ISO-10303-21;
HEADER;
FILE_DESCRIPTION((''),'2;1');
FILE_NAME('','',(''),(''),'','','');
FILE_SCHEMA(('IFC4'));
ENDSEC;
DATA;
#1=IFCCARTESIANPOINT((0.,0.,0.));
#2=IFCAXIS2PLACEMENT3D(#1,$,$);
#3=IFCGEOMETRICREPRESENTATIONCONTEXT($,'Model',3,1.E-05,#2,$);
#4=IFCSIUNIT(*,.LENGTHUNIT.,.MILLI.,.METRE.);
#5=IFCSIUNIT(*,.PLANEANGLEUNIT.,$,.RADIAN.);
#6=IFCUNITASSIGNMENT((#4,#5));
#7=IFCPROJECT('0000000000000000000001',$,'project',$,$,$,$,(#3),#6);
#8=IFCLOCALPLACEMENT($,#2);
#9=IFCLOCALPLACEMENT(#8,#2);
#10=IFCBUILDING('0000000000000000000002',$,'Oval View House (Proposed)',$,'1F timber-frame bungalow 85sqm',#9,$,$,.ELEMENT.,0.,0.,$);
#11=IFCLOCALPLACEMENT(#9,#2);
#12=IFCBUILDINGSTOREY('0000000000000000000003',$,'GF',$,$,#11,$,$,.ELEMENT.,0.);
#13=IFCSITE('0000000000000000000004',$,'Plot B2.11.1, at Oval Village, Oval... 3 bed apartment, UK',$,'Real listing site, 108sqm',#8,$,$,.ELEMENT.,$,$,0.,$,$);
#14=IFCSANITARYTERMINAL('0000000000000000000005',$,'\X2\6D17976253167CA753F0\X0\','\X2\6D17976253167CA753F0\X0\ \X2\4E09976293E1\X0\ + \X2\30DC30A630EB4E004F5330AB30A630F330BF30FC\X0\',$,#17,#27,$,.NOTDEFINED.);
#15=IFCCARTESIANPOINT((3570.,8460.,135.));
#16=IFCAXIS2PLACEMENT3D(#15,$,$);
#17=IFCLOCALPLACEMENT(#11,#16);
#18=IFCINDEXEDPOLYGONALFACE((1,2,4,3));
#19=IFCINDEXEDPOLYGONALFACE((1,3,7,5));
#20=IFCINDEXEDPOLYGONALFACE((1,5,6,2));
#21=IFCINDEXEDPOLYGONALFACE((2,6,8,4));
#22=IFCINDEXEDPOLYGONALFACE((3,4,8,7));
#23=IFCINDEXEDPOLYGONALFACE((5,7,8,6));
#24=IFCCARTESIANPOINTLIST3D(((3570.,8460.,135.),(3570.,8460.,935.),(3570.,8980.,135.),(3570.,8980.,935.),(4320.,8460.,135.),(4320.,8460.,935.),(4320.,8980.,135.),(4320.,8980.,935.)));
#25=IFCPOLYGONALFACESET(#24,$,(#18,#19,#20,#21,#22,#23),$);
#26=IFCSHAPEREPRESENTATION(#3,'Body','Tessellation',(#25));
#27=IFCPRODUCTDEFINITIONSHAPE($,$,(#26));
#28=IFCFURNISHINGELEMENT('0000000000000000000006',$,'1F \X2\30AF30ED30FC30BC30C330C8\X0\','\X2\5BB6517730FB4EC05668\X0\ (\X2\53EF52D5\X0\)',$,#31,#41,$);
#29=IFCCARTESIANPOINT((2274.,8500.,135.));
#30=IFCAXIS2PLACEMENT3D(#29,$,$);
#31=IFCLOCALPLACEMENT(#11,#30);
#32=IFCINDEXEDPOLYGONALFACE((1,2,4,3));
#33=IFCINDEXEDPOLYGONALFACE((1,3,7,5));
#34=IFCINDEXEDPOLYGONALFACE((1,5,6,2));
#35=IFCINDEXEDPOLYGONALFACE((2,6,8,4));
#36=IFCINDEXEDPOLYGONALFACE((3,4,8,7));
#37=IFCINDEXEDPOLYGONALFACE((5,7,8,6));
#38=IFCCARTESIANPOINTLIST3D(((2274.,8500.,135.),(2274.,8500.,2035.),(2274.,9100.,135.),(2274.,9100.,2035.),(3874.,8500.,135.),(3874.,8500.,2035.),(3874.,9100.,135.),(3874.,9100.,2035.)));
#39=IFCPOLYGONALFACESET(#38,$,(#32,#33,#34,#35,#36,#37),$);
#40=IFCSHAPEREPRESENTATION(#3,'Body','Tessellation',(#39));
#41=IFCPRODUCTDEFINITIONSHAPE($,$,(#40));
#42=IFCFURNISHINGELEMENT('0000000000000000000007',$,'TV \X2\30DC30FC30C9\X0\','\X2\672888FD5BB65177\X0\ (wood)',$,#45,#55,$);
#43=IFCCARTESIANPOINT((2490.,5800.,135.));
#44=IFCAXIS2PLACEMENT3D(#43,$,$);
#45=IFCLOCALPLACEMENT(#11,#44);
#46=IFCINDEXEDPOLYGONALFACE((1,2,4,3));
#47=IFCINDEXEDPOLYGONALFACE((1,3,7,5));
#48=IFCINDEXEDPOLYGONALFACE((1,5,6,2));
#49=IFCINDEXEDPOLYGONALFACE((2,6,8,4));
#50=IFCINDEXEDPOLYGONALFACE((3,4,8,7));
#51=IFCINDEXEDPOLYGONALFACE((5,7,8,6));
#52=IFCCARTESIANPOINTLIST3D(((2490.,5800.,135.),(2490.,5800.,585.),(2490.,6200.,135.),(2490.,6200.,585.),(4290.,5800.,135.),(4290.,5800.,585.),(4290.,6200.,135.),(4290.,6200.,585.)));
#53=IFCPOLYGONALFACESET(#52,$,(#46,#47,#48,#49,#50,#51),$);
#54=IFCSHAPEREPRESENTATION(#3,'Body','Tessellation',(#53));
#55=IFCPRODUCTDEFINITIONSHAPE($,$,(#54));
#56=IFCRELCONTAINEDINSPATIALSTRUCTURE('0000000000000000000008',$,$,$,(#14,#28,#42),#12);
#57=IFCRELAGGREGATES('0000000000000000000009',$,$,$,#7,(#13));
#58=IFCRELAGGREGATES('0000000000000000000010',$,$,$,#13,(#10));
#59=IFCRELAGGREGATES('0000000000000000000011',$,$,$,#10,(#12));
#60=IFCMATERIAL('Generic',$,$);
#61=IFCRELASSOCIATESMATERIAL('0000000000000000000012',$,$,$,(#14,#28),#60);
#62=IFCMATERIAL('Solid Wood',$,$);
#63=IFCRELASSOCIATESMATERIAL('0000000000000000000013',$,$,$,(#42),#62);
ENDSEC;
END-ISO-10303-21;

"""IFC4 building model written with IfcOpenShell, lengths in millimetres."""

from ifc_helpers import new_model, si_unit, frame, frame_2d, origin, place, context, project, spatial, rectangle, extrude, material, element, save


model = new_model("IFC4")

# Units and contexts
model_context = context("Model", 3, precision=1e-05, world=origin())
ifc_project = project(units=[si_unit("LENGTHUNIT", "METRE", prefix="MILLI"), si_unit("PLANEANGLEUNIT", "RADIAN")], contexts=[model_context])

# Site, building, storey
site_placement = place(None, origin())
site = spatial("IfcSite", under=ifc_project, at=site_placement, Name="Plot B2.11.1, at Oval Village, Oval... 3 bed apartment, UK", ObjectType="Real listing site, 108sqm", CompositionType="ELEMENT", RefElevation=0.0)
building_placement = place(site_placement, origin())
building = spatial("IfcBuilding", under=site, at=building_placement, Name="Oval View House (Proposed)", ObjectType="1F timber-frame bungalow 85sqm", CompositionType="ELEMENT", ElevationOfRefHeight=0.0, ElevationOfTerrain=0.0)
storey_placement = place(building_placement, origin())
storey = spatial("IfcBuildingStorey", under=building, at=storey_placement, Name="GF", CompositionType="ELEMENT", Elevation=0.0)

# Shared definitions
ifc_material_1 = material(Name="Solid Wood")

# Shared definitions
ifc_material_2 = material(Name="Generic")

# Sanitary terminal
sanitary_terminal_1_placement = place(storey_placement, frame((3570.0, 8460.0, 135.0)))
element("IfcSanitaryTerminal", 1, at=sanitary_terminal_1_placement, inside=storey, material=ifc_material_2, Name="洗面化粧台", Description="洗面化粧台 三面鏡 + ボウル一体カウンター", PredefinedType="NOTDEFINED", context=model_context, shape_type="SweptSolid", body=[
    extrude(rectangle(XDim=750.0, YDim=520.0, at=frame_2d((375.0, 260.0))), frame((3570.0, 8460.0, 135.0)), (0.0, 0.0, 1.0), 800.0),
])

# Furnishing elements
furnishing_1_placement = place(storey_placement, frame((2274.0, 8500.0, 135.0)))
element("IfcFurnishingElement", 2, at=furnishing_1_placement, inside=storey, material=ifc_material_2, Name="1F クローゼット", Description="家具・什器 (可動)", context=model_context, shape_type="SweptSolid", body=[
    extrude(rectangle(XDim=1600.0, YDim=600.0, at=frame_2d((800.0, 300.0))), frame((2274.0, 8500.0, 135.0)), (0.0, 0.0, 1.0), 1900.0),
])
furnishing_2_placement = place(storey_placement, frame((2490.0, 5800.0, 135.0)))
element("IfcFurnishingElement", 3, at=furnishing_2_placement, inside=storey, material=ifc_material_1, Name="TV ボード", Description="木製家具 (wood)", context=model_context, shape_type="SweptSolid", body=[
    extrude(rectangle(XDim=1800.0, YDim=400.0, at=frame_2d((900.0, 200.0))), frame((2490.0, 5800.0, 135.0)), (0.0, 0.0, 1.0), 450.0),
])

save(model, "model.ifc")
